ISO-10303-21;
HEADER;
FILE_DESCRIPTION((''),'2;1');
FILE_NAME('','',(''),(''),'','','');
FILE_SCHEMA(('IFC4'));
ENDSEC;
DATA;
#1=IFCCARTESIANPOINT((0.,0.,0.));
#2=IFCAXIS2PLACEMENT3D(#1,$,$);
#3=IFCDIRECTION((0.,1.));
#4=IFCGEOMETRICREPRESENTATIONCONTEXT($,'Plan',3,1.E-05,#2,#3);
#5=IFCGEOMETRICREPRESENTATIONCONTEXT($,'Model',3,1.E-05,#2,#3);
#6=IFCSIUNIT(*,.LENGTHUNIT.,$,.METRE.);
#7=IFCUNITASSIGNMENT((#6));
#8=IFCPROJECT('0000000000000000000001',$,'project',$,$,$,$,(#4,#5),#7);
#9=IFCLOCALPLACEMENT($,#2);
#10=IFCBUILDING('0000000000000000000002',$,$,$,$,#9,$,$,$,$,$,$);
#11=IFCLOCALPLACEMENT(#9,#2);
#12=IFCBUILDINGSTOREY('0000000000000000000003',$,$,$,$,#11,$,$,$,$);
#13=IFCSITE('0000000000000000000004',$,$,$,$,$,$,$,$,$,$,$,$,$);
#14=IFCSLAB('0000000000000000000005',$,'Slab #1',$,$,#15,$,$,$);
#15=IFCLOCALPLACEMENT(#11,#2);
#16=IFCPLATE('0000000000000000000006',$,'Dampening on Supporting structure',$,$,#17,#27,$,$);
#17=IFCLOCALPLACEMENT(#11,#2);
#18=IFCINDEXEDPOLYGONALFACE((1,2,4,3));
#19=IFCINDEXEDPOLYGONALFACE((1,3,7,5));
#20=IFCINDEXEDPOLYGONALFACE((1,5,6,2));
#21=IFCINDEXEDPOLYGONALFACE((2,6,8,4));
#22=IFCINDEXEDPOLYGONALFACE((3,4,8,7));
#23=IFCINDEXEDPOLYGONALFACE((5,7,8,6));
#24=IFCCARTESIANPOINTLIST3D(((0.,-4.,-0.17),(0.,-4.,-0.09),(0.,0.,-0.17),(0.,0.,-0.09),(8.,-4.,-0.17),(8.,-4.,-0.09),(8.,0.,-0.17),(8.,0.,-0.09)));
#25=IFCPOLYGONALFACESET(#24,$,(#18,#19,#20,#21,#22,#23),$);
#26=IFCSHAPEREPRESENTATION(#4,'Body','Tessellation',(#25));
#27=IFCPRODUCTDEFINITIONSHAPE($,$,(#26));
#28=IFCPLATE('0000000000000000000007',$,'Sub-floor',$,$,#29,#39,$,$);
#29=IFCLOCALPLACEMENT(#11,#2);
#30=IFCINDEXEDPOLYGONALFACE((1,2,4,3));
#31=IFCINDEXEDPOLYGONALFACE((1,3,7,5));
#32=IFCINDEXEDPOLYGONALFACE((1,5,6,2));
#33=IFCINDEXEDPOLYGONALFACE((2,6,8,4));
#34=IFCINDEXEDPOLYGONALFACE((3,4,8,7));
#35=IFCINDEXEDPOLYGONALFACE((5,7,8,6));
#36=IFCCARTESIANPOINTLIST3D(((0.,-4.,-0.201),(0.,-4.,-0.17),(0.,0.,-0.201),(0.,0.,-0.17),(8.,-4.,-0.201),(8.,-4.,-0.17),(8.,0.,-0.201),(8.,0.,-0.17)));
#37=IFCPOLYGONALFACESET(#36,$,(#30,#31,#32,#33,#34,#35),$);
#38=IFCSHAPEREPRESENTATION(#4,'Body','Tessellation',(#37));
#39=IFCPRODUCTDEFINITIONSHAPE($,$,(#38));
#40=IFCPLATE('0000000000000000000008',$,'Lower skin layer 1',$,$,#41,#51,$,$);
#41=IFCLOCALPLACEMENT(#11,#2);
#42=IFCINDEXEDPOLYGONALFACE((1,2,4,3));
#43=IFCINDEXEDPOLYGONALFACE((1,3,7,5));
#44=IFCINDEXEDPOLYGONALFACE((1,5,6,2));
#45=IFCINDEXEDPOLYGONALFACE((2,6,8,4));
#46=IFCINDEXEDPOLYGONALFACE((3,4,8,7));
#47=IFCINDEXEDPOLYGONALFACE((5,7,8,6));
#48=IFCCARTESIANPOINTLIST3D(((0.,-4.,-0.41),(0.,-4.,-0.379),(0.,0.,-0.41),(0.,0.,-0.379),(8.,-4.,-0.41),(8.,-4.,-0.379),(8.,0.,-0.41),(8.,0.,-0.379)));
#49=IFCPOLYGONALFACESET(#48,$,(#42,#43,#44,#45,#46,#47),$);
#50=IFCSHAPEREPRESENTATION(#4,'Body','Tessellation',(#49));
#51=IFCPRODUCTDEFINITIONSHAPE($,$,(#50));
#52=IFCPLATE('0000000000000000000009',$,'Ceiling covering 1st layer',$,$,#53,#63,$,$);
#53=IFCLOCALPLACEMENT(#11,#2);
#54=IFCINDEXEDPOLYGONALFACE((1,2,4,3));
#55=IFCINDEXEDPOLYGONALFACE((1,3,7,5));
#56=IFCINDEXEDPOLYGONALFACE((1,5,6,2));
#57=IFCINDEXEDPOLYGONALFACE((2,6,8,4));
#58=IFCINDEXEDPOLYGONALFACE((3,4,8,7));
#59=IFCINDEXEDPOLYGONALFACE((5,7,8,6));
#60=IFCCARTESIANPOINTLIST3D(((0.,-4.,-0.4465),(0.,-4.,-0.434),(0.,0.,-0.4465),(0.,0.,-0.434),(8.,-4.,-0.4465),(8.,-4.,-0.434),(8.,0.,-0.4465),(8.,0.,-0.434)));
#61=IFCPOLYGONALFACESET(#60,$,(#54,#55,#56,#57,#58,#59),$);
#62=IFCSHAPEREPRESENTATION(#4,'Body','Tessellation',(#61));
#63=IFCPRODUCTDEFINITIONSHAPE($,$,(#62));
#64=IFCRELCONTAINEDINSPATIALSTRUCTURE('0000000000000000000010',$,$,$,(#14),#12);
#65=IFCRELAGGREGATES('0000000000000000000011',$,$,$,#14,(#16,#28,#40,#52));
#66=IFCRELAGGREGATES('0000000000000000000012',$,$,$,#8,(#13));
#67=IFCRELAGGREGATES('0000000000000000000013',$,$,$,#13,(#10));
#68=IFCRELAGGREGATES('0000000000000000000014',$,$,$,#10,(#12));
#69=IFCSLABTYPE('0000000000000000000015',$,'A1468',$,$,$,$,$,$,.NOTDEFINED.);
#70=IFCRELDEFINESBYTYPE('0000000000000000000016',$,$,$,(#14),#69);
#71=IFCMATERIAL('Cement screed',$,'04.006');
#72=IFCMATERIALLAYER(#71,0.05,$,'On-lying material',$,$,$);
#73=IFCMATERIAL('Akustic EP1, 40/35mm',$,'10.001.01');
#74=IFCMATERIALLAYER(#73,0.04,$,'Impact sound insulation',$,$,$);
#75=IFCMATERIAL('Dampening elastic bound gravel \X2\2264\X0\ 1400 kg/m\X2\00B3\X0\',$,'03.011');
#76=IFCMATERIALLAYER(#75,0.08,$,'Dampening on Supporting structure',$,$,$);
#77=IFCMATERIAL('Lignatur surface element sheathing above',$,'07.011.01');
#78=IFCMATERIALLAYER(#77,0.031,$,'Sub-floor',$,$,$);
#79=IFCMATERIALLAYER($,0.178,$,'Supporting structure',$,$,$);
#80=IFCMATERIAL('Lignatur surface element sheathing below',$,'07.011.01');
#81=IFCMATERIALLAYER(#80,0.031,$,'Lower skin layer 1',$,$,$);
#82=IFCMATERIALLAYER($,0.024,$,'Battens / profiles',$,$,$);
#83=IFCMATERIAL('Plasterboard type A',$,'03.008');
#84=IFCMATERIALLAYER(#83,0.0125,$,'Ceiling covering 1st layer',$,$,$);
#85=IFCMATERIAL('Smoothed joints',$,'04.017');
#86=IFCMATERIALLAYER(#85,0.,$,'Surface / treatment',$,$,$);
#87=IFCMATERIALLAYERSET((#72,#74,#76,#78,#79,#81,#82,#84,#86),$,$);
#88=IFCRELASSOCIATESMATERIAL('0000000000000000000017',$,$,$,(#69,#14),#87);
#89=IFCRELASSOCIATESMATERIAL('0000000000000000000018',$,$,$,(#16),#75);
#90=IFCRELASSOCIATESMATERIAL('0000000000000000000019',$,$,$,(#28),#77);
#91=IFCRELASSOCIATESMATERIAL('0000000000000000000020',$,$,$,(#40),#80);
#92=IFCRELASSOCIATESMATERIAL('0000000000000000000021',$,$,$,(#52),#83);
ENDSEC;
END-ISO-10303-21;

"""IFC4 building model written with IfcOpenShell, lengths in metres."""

from ifc_helpers import new_model, si_unit, direction, frame, frame_2d, origin, place, context, project, spatial, rectangle, extrude, material, layer, layer_set, type_object, element, aggregate, save


model = new_model("IFC4")

# Units and contexts
plan_context = context("Plan", 3, precision=1e-05, world=origin(), true_north=direction((0.0, 1.0)))
model_context = context("Model", 3, precision=1e-05, world=origin(), true_north=direction((0.0, 1.0)))
ifc_project = project(units=[si_unit("LENGTHUNIT", "METRE")], contexts=[plan_context, model_context])

# Site, building, storey
site = spatial("IfcSite", under=ifc_project)
building_placement = place(None, origin())
building = spatial("IfcBuilding", under=site, at=building_placement)
storey_placement = place(building_placement, origin())
storey = spatial("IfcBuildingStorey", under=building, at=storey_placement)

# Slab, plates
ifc_material_1 = material(Name="Cement screed", Category="04.006")
ifc_layer_1 = layer(ifc_material_1, 0.05, Name="On-lying material")
ifc_material_2 = material(Name="Akustic EP1, 40/35mm", Category="10.001.01")
ifc_layer_2 = layer(ifc_material_2, 0.04, Name="Impact sound insulation")
ifc_material_3 = material(Name="Dampening elastic bound gravel ≤ 1400 kg/m³", Category="03.011")
ifc_layer_3 = layer(ifc_material_3, 0.08, Name="Dampening on Supporting structure")
ifc_material_4 = material(Name="Lignatur surface element sheathing above", Category="07.011.01")
ifc_layer_4 = layer(ifc_material_4, 0.031, Name="Sub-floor")
ifc_layer_5 = layer(None, 0.178, Name="Supporting structure")
ifc_material_5 = material(Name="Lignatur surface element sheathing below", Category="07.011.01")
ifc_layer_6 = layer(ifc_material_5, 0.031, Name="Lower skin layer 1")
ifc_layer_7 = layer(None, 0.024, Name="Battens / profiles")
ifc_material_6 = material(Name="Plasterboard type A", Category="03.008")
ifc_layer_8 = layer(ifc_material_6, 0.0125, Name="Ceiling covering 1st layer")
ifc_material_7 = material(Name="Smoothed joints", Category="04.017")
ifc_layer_9 = layer(ifc_material_7, 0.0, Name="Surface / treatment")
ifc_layer_set = layer_set([ifc_layer_1, ifc_layer_2, ifc_layer_3, ifc_layer_4, ifc_layer_5, ifc_layer_6, ifc_layer_7, ifc_layer_8, ifc_layer_9])
slab_type = type_object("IfcSlabType", Name="A1468", PredefinedType="NOTDEFINED", material=ifc_layer_set)
slab_placement = place(None, frame((0.0, 0.0, 0.0), z_axis=(0.0, 0.0, -1.0), x_axis=(1.0, 0.0, 0.0)))
slab = element("IfcSlab", 1, at=slab_placement, inside=storey, type_object=slab_type, material=ifc_layer_set, Name="Slab #1")
plate_1_placement = place(slab_placement, origin())
plate_1 = element("IfcPlate", 2, at=plate_1_placement, material=ifc_material_3, Name="Dampening on Supporting structure", context=plan_context, shape_type="SweptSolid", body=[
    extrude(rectangle(XDim=8.0, YDim=4.0, at=frame_2d((4.0, 2.0), x_axis=(1.0, 0.0))), frame((0.0, 0.0, 0.09), z_axis=(0.0, 0.0, 1.0), x_axis=(1.0, 0.0, 0.0)), (0.0, 0.0, 1.0), 0.08),
])
plate_2_placement = place(slab_placement, origin())
plate_2 = element("IfcPlate", 3, at=plate_2_placement, material=ifc_material_4, Name="Sub-floor", context=plan_context, shape_type="SweptSolid", body=[
    extrude(rectangle(XDim=8.0, YDim=4.0, at=frame_2d((4.0, 2.0), x_axis=(1.0, 0.0))), frame((0.0, 0.0, 0.17), z_axis=(0.0, 0.0, 1.0), x_axis=(1.0, 0.0, 0.0)), (0.0, 0.0, 1.0), 0.031),
])
plate_3_placement = place(slab_placement, origin())
plate_3 = element("IfcPlate", 4, at=plate_3_placement, material=ifc_material_5, Name="Lower skin layer 1", context=plan_context, shape_type="SweptSolid", body=[
    extrude(rectangle(XDim=8.0, YDim=4.0, at=frame_2d((4.0, 2.0), x_axis=(1.0, 0.0))), frame((0.0, 0.0, 0.379), z_axis=(0.0, 0.0, 1.0), x_axis=(1.0, 0.0, 0.0)), (0.0, 0.0, 1.0), 0.031),
])
plate_4_placement = place(slab_placement, origin())
plate_4 = element("IfcPlate", 5, at=plate_4_placement, material=ifc_material_6, Name="Ceiling covering 1st layer", context=plan_context, shape_type="SweptSolid", body=[
    extrude(rectangle(XDim=8.0, YDim=4.0, at=frame_2d((4.0, 2.0), x_axis=(1.0, 0.0))), frame((0.0, 0.0, 0.434), z_axis=(0.0, 0.0, 1.0), x_axis=(1.0, 0.0, 0.0)), (0.0, 0.0, 1.0), 0.0125),
])
aggregate(slab, [plate_1, plate_2, plate_3, plate_4])

save(model, "model.ifc")
